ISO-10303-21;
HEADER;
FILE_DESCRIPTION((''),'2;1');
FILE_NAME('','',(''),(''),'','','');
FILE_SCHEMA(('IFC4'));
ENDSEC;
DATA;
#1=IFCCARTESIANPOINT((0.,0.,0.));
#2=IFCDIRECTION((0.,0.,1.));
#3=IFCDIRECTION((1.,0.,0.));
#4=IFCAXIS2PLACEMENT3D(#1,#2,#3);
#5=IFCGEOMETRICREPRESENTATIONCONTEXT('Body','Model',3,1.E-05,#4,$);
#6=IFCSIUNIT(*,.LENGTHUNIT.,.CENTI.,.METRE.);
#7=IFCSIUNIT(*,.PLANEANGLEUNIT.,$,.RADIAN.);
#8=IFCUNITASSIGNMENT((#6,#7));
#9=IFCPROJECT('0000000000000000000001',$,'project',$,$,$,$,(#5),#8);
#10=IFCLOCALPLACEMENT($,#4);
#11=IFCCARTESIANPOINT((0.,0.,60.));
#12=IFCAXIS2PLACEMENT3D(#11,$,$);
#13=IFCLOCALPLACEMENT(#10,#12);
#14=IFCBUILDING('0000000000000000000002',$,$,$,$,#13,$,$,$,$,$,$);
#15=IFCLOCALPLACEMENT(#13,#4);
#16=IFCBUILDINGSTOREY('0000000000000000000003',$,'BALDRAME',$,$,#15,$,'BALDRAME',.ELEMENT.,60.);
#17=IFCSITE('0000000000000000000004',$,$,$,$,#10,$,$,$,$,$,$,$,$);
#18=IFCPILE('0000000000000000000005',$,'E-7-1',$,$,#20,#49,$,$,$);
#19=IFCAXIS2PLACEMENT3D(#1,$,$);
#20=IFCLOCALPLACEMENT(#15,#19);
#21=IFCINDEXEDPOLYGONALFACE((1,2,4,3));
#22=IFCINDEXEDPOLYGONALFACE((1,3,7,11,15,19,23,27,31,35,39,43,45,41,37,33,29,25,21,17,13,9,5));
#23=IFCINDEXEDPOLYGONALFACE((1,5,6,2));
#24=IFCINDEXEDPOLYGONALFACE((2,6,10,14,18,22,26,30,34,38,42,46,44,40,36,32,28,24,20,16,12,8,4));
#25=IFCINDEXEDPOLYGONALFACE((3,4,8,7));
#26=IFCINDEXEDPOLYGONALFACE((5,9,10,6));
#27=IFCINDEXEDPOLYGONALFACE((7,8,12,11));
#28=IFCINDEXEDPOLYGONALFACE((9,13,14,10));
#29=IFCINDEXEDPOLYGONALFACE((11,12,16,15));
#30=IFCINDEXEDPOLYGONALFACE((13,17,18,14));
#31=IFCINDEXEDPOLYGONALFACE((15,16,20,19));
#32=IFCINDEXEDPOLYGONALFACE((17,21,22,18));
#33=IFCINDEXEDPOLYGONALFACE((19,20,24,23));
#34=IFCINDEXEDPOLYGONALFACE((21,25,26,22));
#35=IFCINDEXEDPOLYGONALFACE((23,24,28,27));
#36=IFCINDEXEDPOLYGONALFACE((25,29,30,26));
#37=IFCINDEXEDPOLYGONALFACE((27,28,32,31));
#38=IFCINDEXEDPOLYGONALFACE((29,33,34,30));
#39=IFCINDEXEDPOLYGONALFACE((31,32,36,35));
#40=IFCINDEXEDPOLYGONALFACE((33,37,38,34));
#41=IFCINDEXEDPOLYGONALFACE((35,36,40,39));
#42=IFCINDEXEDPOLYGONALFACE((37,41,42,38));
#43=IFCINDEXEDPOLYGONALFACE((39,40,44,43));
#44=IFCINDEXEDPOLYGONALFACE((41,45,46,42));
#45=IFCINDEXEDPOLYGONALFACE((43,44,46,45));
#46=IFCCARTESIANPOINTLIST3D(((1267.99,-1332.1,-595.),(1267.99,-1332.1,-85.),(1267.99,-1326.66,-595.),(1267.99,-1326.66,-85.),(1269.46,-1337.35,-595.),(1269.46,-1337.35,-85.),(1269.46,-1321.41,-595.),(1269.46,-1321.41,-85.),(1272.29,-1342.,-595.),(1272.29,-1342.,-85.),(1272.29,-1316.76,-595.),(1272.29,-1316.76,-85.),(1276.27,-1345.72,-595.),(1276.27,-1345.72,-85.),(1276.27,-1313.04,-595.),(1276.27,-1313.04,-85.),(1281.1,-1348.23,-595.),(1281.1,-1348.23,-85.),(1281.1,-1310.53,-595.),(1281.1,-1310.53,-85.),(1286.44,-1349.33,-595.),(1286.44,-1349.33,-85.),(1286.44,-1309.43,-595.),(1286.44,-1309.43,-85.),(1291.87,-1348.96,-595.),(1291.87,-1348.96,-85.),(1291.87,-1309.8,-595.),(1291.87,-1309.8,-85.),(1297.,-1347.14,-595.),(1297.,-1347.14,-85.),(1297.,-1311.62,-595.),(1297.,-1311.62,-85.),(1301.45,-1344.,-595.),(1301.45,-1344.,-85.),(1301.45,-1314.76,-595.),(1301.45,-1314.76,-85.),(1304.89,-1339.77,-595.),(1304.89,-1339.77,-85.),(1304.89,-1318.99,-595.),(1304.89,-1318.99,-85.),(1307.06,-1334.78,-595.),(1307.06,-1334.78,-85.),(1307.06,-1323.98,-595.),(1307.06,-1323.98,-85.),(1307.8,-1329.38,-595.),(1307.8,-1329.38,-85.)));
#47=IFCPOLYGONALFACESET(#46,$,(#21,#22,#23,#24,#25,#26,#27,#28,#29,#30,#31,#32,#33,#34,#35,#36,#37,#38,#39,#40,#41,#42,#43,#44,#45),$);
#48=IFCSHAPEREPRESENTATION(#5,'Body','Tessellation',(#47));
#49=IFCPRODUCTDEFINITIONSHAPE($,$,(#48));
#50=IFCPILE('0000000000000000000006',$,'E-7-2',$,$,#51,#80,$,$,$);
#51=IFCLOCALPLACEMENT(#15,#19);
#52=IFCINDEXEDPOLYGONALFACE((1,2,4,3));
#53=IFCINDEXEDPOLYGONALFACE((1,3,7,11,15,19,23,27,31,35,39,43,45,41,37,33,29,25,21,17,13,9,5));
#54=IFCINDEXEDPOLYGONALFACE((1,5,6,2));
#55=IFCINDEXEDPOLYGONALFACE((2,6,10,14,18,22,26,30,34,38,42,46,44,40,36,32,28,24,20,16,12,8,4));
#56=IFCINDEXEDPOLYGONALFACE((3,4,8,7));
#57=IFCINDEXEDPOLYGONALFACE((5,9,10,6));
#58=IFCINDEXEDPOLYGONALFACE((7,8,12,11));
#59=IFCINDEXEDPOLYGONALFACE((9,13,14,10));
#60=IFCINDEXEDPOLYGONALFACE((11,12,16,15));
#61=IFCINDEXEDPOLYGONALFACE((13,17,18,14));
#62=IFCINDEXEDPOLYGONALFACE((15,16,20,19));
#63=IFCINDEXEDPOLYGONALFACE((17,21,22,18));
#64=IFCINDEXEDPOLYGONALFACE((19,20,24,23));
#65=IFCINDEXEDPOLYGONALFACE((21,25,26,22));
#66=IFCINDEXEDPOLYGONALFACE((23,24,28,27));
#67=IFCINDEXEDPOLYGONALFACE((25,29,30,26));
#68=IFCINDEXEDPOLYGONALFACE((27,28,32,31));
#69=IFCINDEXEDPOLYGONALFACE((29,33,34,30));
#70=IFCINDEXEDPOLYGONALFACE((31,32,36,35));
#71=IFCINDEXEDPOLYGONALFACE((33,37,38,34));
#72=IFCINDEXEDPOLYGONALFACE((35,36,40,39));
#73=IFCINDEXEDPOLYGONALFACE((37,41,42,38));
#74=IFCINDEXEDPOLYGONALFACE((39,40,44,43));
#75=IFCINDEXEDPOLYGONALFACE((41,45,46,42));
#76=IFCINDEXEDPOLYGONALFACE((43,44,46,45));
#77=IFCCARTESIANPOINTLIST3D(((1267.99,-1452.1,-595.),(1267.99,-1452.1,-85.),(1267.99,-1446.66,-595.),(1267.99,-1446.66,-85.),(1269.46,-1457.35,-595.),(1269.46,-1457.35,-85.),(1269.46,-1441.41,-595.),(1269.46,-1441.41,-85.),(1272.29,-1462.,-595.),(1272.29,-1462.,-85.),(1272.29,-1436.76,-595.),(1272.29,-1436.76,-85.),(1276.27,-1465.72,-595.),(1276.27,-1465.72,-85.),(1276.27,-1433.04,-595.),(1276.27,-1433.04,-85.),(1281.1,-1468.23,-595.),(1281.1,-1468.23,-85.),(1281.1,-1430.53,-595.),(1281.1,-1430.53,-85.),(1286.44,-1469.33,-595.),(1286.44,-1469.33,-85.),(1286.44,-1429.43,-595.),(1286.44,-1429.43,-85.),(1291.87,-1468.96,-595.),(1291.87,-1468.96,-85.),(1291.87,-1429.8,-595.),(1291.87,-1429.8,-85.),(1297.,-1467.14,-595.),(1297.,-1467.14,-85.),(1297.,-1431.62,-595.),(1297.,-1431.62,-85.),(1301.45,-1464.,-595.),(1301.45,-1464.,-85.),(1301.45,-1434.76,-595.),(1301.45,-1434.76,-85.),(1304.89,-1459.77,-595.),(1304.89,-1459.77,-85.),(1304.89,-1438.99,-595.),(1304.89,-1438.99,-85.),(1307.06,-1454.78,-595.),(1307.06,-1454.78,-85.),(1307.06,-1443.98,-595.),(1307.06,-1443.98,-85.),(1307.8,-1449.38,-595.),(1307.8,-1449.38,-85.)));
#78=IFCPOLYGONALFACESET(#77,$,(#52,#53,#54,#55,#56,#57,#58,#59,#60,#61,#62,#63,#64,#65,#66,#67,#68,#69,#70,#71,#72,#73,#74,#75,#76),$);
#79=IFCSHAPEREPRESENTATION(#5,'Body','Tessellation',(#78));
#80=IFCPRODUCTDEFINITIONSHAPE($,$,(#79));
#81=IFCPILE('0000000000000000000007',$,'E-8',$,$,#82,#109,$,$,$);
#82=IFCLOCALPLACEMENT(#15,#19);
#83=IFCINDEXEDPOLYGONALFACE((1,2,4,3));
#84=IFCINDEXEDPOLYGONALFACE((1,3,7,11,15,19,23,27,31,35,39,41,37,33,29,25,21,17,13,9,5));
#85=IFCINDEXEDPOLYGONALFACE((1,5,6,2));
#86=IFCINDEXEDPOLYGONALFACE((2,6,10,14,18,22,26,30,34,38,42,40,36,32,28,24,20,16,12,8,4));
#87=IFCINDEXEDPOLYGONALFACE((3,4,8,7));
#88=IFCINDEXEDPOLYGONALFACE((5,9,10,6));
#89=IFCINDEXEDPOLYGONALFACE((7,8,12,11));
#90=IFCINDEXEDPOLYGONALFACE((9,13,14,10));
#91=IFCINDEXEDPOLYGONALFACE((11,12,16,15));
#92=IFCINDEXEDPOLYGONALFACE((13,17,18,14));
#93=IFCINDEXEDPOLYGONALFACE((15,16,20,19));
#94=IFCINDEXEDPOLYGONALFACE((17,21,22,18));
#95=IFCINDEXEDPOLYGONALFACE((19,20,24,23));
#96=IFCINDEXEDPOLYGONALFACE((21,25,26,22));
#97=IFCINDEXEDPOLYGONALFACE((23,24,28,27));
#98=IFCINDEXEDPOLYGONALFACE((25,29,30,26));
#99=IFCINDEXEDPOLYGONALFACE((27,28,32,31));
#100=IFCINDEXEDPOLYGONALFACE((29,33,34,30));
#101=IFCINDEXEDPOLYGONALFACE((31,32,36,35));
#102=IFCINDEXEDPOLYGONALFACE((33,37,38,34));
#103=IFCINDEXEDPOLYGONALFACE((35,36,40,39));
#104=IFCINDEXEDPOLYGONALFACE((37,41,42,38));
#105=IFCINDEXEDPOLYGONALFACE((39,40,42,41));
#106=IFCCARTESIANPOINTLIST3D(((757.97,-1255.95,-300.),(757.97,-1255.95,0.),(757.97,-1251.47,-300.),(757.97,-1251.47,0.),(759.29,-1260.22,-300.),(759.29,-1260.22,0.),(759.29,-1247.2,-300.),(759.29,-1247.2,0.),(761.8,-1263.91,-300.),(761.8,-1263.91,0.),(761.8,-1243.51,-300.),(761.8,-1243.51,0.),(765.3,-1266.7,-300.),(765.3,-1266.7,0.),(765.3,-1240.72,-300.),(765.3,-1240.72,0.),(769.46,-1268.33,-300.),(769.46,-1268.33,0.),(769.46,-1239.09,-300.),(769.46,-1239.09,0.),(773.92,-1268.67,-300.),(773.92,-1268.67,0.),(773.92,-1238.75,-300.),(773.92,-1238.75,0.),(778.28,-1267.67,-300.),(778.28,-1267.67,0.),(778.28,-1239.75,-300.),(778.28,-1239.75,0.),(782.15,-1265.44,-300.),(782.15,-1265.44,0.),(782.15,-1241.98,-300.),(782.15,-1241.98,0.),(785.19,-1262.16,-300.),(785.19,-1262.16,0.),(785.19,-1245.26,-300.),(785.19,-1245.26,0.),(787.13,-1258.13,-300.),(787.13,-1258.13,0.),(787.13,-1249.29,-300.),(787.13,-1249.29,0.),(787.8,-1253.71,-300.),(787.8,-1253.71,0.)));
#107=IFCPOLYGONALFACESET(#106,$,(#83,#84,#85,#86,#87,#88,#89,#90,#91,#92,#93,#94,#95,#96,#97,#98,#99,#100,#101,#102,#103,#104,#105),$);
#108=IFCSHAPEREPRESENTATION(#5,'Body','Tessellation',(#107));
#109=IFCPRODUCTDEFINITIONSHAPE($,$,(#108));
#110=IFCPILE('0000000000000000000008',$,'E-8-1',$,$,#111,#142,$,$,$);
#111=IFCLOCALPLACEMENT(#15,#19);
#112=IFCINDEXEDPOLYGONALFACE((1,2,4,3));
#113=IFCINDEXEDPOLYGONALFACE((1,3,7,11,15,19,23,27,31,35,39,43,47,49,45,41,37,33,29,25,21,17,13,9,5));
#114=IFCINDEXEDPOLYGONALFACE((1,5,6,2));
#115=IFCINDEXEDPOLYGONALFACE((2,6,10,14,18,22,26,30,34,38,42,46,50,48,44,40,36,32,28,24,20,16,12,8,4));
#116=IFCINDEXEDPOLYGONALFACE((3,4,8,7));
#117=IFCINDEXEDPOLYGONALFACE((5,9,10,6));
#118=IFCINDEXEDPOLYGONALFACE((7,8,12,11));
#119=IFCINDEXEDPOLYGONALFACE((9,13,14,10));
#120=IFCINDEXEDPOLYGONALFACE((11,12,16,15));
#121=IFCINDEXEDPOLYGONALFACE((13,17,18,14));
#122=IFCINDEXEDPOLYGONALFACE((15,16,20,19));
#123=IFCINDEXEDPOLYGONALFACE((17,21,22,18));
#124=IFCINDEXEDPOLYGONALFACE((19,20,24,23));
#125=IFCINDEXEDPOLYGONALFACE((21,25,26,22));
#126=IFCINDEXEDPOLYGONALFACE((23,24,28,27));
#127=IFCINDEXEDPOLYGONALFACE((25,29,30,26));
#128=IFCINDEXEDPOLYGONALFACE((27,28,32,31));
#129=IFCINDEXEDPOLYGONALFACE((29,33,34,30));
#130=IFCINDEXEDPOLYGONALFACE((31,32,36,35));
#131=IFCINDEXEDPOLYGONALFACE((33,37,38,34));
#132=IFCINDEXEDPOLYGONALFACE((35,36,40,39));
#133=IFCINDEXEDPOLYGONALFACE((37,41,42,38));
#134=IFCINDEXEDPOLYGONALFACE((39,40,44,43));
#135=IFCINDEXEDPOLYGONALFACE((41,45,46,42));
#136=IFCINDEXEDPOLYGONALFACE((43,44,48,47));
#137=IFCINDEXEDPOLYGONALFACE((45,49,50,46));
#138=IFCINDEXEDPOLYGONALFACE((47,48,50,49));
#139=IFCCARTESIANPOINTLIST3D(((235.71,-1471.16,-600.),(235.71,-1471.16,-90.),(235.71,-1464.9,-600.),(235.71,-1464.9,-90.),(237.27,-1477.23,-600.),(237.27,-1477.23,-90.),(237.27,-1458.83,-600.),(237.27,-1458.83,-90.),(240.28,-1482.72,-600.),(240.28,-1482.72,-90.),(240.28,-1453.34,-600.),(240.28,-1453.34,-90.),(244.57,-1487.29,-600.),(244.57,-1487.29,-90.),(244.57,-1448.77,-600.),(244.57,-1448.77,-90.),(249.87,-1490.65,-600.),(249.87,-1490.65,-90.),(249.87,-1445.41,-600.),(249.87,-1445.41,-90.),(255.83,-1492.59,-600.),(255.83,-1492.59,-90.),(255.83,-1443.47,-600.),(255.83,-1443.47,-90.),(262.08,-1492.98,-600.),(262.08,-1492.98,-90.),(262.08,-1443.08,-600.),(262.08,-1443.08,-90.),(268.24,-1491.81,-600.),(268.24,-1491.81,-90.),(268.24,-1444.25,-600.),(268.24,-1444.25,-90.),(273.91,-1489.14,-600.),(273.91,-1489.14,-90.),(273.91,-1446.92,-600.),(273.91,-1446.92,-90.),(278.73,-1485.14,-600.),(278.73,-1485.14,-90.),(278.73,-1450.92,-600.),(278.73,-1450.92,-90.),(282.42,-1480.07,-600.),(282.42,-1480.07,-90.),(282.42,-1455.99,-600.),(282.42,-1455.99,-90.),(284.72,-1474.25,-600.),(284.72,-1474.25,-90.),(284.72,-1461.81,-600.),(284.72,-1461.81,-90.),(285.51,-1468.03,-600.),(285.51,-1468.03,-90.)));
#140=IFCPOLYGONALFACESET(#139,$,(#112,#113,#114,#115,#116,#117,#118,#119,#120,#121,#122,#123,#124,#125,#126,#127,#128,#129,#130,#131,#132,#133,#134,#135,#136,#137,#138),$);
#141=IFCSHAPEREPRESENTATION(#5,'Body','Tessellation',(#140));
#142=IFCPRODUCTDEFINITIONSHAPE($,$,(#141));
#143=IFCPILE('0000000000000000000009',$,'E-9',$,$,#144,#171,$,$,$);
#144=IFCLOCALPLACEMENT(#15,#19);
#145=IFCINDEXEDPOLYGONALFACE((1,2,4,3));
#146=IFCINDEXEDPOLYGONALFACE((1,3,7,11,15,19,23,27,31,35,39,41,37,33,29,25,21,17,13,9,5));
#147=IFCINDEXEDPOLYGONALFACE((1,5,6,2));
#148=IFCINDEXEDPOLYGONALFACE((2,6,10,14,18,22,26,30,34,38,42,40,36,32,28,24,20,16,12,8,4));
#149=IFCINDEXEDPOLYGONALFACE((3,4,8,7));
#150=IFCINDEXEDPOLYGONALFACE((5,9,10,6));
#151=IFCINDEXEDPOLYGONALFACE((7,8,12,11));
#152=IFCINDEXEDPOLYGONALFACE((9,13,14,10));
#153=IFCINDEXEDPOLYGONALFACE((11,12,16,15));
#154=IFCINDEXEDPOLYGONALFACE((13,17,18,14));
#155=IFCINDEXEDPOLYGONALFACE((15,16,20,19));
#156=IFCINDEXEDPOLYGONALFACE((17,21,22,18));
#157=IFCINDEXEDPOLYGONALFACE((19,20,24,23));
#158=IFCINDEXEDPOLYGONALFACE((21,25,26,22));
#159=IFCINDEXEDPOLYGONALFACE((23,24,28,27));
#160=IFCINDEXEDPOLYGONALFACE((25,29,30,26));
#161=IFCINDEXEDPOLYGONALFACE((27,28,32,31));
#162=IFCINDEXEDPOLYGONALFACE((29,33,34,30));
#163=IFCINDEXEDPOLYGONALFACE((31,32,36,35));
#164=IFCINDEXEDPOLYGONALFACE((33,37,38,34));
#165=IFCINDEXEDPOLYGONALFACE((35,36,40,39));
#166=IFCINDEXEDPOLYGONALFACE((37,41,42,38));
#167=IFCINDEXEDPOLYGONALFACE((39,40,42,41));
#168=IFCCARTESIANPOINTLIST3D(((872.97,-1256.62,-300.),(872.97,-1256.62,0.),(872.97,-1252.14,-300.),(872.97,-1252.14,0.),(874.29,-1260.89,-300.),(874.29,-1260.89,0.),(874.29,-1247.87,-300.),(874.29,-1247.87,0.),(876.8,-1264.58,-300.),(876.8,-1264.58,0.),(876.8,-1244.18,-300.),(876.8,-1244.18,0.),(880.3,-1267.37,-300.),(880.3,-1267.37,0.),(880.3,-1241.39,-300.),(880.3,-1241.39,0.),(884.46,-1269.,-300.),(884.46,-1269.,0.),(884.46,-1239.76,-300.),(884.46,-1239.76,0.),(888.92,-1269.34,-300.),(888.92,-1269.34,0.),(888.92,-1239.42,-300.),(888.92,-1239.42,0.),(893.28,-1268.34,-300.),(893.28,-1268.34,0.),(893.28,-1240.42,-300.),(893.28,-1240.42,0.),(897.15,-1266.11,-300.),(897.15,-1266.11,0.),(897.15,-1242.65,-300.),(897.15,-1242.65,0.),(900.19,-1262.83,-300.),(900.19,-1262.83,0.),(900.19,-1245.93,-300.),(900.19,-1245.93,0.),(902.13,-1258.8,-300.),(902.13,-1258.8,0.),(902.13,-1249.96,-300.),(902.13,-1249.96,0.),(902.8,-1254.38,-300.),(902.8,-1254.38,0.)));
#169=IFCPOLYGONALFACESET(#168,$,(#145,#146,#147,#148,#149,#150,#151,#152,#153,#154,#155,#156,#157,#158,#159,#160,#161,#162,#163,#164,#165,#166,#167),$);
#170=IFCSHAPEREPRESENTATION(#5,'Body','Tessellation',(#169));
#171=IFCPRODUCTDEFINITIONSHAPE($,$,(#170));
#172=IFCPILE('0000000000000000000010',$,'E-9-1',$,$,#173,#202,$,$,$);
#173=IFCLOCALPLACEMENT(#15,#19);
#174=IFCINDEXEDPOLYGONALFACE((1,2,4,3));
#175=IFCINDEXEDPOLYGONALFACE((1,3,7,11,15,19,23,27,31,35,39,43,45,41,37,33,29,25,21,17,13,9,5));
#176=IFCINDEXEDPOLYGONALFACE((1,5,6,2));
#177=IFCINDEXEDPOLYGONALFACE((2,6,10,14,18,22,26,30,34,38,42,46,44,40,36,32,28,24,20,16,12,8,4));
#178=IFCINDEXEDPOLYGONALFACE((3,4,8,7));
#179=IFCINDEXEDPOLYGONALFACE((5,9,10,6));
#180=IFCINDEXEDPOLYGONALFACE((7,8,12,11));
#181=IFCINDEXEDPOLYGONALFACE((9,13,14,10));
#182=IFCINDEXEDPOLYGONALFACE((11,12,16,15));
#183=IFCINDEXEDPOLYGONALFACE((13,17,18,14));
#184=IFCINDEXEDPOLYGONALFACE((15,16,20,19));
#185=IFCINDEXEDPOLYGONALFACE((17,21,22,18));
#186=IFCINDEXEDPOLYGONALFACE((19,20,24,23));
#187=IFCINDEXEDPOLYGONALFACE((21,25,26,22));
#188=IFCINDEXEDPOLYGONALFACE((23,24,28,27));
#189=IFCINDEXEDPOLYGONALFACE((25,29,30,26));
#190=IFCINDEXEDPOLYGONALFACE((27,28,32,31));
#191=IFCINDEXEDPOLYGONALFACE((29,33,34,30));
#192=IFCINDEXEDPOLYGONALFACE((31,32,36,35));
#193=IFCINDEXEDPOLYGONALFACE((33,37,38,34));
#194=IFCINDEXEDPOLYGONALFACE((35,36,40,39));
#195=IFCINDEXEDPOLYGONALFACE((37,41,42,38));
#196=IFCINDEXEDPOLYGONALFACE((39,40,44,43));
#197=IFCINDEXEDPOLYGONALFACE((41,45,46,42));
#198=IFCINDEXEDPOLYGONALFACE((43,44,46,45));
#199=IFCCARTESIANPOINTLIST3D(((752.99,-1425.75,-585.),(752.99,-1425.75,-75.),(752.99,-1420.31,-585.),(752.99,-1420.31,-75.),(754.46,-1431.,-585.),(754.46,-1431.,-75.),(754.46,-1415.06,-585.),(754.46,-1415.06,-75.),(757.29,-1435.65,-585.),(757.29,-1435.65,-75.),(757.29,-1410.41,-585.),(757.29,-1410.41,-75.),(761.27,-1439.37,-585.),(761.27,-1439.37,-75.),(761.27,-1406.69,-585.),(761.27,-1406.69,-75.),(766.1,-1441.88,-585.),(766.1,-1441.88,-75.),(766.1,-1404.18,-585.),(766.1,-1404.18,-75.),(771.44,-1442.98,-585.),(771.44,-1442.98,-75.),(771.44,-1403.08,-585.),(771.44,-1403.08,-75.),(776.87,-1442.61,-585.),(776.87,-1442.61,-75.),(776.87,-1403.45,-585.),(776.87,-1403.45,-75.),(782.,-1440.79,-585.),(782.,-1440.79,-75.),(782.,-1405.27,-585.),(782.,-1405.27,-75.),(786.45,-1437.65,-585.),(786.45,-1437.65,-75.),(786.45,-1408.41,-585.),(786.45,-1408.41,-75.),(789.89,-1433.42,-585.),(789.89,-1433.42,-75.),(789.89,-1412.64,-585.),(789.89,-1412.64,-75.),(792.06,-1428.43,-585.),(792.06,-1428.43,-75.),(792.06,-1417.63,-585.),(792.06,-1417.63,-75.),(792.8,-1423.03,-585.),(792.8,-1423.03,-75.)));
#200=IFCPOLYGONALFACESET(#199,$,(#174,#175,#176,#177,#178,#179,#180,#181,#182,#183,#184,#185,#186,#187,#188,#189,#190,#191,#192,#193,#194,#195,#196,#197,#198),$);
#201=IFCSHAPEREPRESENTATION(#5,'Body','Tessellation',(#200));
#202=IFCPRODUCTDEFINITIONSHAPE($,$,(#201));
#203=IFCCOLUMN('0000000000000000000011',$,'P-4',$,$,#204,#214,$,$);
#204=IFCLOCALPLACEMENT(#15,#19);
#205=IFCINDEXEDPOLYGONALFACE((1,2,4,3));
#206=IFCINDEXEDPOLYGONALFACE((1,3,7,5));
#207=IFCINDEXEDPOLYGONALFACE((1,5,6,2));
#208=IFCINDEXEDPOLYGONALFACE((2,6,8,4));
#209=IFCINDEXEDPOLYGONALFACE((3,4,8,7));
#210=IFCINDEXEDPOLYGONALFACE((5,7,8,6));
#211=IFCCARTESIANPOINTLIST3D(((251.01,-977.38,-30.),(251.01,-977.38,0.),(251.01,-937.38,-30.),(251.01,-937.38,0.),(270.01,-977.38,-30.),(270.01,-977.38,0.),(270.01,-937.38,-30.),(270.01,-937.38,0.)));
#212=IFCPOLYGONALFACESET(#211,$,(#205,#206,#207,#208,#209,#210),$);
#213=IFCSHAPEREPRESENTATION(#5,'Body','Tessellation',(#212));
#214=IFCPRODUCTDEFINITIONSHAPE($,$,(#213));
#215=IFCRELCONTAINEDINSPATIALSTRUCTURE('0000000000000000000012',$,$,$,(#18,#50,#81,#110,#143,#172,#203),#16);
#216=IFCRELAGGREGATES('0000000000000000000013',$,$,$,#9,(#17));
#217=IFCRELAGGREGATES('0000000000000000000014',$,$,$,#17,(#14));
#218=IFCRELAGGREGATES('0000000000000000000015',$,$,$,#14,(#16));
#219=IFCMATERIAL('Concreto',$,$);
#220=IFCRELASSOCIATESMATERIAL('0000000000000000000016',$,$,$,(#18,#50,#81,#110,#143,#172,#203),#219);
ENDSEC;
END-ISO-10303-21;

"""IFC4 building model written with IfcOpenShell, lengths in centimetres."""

from ifc_helpers import new_model, si_unit, frame, origin_with_axes, origin_2d_with_axis, place, context, project, spatial, rectangle, circle, extrude, material, element, save


model = new_model("IFC4")

# Units and contexts
model_context = context("Model", 3, precision=1e-05, world=origin_with_axes(), identifier="Body")
ifc_project = project(units=[si_unit("LENGTHUNIT", "METRE", prefix="CENTI"), si_unit("PLANEANGLEUNIT", "RADIAN")], contexts=[model_context])

# Site, building, storey
site_placement = place(None, origin_with_axes())
site = spatial("IfcSite", under=ifc_project, at=site_placement)
building_placement = place(site_placement, frame((0.0, 0.0, 60.0)))
building = spatial("IfcBuilding", under=site, at=building_placement)
storey_placement = place(building_placement, origin_with_axes())
storey = spatial("IfcBuildingStorey", under=building, at=storey_placement, Name="BALDRAME", LongName="BALDRAME", CompositionType="ELEMENT", Elevation=60.0)

# Piles
ifc_material = material(Name="Concreto")
for number, where, z_axis, x_axis, name in (
    (1, (1287.8, -1329.38, -85.0), (0.0, 0.0, 1.0), (1.0, 0.0, 0.0), "E-7-1"),
    (2, (1287.8, -1449.38, -85.0), (0.0, 0.0, 1.0), (1.0, 0.0, 0.0), "E-7-2"),
):
    element("IfcPile", number, at=place(storey_placement, frame(where, z_axis=z_axis, x_axis=x_axis)), inside=storey, material=ifc_material, Name=name, context=model_context, shape_type="SweptSolid", body=[
        extrude(circle(Radius=20.0, at=origin_2d_with_axis()), frame((0.0, 0.0, -510.0), z_axis=(0.0, 0.0, 1.0), x_axis=(1.0, 0.0, 0.0)), (0.0, 0.0, 1.0), 510.0),
    ])
pile_1_placement = place(storey_placement, frame((772.8, -1253.71, 0.0), z_axis=(0.0, 0.0, 1.0), x_axis=(1.0, 0.0, 0.0)))
element("IfcPile", 3, at=pile_1_placement, inside=storey, material=ifc_material, Name="E-8", context=model_context, shape_type="SolidModel", body=[
    extrude(circle(Radius=15.0, at=origin_2d_with_axis()), frame((0.0, 0.0, -300.0), z_axis=(0.0, 0.0, 1.0), x_axis=(1.0, 0.0, 0.0)), (0.0, 0.0, 1.0), 300.0),
])
pile_2_placement = place(storey_placement, frame((260.51, -1468.03, -90.0), z_axis=(0.0, 0.0, 1.0), x_axis=(1.0, 0.0, 0.0)))
element("IfcPile", 4, at=pile_2_placement, inside=storey, material=ifc_material, Name="E-8-1", context=model_context, shape_type="SweptSolid", body=[
    extrude(circle(Radius=25.0, at=origin_2d_with_axis()), frame((0.0, 0.0, -510.0), z_axis=(0.0, 0.0, 1.0), x_axis=(1.0, 0.0, 0.0)), (0.0, 0.0, 1.0), 510.0),
])
pile_3_placement = place(storey_placement, frame((887.8, -1254.38, 0.0), z_axis=(0.0, 0.0, 1.0), x_axis=(1.0, 0.0, 0.0)))
element("IfcPile", 5, at=pile_3_placement, inside=storey, material=ifc_material, Name="E-9", context=model_context, shape_type="SolidModel", body=[
    extrude(circle(Radius=15.0, at=origin_2d_with_axis()), frame((0.0, 0.0, -300.0), z_axis=(0.0, 0.0, 1.0), x_axis=(1.0, 0.0, 0.0)), (0.0, 0.0, 1.0), 300.0),
])
pile_4_placement = place(storey_placement, frame((772.8, -1423.03, -75.0), z_axis=(0.0, 0.0, 1.0), x_axis=(1.0, 0.0, 0.0)))
element("IfcPile", 6, at=pile_4_placement, inside=storey, material=ifc_material, Name="E-9-1", context=model_context, shape_type="SweptSolid", body=[
    extrude(circle(Radius=20.0, at=origin_2d_with_axis()), frame((0.0, 0.0, -510.0), z_axis=(0.0, 0.0, 1.0), x_axis=(1.0, 0.0, 0.0)), (0.0, 0.0, 1.0), 510.0),
])

# Column
column_placement = place(storey_placement, frame((260.51, -957.38, 0.0), z_axis=(0.0, 0.0, 1.0), x_axis=(1.0, 0.0, 0.0)))
element("IfcColumn", 7, at=column_placement, inside=storey, material=ifc_material, Name="P-4", context=model_context, shape_type="SolidModel", body=[
    extrude(rectangle(XDim=19.0, YDim=40.0, at=origin_2d_with_axis()), frame((0.0, 0.0, -30.0), z_axis=(0.0, 0.0, 1.0), x_axis=(1.0, 0.0, 0.0)), (0.0, 0.0, 1.0), 30.0),
])

save(model, "model.ifc")
